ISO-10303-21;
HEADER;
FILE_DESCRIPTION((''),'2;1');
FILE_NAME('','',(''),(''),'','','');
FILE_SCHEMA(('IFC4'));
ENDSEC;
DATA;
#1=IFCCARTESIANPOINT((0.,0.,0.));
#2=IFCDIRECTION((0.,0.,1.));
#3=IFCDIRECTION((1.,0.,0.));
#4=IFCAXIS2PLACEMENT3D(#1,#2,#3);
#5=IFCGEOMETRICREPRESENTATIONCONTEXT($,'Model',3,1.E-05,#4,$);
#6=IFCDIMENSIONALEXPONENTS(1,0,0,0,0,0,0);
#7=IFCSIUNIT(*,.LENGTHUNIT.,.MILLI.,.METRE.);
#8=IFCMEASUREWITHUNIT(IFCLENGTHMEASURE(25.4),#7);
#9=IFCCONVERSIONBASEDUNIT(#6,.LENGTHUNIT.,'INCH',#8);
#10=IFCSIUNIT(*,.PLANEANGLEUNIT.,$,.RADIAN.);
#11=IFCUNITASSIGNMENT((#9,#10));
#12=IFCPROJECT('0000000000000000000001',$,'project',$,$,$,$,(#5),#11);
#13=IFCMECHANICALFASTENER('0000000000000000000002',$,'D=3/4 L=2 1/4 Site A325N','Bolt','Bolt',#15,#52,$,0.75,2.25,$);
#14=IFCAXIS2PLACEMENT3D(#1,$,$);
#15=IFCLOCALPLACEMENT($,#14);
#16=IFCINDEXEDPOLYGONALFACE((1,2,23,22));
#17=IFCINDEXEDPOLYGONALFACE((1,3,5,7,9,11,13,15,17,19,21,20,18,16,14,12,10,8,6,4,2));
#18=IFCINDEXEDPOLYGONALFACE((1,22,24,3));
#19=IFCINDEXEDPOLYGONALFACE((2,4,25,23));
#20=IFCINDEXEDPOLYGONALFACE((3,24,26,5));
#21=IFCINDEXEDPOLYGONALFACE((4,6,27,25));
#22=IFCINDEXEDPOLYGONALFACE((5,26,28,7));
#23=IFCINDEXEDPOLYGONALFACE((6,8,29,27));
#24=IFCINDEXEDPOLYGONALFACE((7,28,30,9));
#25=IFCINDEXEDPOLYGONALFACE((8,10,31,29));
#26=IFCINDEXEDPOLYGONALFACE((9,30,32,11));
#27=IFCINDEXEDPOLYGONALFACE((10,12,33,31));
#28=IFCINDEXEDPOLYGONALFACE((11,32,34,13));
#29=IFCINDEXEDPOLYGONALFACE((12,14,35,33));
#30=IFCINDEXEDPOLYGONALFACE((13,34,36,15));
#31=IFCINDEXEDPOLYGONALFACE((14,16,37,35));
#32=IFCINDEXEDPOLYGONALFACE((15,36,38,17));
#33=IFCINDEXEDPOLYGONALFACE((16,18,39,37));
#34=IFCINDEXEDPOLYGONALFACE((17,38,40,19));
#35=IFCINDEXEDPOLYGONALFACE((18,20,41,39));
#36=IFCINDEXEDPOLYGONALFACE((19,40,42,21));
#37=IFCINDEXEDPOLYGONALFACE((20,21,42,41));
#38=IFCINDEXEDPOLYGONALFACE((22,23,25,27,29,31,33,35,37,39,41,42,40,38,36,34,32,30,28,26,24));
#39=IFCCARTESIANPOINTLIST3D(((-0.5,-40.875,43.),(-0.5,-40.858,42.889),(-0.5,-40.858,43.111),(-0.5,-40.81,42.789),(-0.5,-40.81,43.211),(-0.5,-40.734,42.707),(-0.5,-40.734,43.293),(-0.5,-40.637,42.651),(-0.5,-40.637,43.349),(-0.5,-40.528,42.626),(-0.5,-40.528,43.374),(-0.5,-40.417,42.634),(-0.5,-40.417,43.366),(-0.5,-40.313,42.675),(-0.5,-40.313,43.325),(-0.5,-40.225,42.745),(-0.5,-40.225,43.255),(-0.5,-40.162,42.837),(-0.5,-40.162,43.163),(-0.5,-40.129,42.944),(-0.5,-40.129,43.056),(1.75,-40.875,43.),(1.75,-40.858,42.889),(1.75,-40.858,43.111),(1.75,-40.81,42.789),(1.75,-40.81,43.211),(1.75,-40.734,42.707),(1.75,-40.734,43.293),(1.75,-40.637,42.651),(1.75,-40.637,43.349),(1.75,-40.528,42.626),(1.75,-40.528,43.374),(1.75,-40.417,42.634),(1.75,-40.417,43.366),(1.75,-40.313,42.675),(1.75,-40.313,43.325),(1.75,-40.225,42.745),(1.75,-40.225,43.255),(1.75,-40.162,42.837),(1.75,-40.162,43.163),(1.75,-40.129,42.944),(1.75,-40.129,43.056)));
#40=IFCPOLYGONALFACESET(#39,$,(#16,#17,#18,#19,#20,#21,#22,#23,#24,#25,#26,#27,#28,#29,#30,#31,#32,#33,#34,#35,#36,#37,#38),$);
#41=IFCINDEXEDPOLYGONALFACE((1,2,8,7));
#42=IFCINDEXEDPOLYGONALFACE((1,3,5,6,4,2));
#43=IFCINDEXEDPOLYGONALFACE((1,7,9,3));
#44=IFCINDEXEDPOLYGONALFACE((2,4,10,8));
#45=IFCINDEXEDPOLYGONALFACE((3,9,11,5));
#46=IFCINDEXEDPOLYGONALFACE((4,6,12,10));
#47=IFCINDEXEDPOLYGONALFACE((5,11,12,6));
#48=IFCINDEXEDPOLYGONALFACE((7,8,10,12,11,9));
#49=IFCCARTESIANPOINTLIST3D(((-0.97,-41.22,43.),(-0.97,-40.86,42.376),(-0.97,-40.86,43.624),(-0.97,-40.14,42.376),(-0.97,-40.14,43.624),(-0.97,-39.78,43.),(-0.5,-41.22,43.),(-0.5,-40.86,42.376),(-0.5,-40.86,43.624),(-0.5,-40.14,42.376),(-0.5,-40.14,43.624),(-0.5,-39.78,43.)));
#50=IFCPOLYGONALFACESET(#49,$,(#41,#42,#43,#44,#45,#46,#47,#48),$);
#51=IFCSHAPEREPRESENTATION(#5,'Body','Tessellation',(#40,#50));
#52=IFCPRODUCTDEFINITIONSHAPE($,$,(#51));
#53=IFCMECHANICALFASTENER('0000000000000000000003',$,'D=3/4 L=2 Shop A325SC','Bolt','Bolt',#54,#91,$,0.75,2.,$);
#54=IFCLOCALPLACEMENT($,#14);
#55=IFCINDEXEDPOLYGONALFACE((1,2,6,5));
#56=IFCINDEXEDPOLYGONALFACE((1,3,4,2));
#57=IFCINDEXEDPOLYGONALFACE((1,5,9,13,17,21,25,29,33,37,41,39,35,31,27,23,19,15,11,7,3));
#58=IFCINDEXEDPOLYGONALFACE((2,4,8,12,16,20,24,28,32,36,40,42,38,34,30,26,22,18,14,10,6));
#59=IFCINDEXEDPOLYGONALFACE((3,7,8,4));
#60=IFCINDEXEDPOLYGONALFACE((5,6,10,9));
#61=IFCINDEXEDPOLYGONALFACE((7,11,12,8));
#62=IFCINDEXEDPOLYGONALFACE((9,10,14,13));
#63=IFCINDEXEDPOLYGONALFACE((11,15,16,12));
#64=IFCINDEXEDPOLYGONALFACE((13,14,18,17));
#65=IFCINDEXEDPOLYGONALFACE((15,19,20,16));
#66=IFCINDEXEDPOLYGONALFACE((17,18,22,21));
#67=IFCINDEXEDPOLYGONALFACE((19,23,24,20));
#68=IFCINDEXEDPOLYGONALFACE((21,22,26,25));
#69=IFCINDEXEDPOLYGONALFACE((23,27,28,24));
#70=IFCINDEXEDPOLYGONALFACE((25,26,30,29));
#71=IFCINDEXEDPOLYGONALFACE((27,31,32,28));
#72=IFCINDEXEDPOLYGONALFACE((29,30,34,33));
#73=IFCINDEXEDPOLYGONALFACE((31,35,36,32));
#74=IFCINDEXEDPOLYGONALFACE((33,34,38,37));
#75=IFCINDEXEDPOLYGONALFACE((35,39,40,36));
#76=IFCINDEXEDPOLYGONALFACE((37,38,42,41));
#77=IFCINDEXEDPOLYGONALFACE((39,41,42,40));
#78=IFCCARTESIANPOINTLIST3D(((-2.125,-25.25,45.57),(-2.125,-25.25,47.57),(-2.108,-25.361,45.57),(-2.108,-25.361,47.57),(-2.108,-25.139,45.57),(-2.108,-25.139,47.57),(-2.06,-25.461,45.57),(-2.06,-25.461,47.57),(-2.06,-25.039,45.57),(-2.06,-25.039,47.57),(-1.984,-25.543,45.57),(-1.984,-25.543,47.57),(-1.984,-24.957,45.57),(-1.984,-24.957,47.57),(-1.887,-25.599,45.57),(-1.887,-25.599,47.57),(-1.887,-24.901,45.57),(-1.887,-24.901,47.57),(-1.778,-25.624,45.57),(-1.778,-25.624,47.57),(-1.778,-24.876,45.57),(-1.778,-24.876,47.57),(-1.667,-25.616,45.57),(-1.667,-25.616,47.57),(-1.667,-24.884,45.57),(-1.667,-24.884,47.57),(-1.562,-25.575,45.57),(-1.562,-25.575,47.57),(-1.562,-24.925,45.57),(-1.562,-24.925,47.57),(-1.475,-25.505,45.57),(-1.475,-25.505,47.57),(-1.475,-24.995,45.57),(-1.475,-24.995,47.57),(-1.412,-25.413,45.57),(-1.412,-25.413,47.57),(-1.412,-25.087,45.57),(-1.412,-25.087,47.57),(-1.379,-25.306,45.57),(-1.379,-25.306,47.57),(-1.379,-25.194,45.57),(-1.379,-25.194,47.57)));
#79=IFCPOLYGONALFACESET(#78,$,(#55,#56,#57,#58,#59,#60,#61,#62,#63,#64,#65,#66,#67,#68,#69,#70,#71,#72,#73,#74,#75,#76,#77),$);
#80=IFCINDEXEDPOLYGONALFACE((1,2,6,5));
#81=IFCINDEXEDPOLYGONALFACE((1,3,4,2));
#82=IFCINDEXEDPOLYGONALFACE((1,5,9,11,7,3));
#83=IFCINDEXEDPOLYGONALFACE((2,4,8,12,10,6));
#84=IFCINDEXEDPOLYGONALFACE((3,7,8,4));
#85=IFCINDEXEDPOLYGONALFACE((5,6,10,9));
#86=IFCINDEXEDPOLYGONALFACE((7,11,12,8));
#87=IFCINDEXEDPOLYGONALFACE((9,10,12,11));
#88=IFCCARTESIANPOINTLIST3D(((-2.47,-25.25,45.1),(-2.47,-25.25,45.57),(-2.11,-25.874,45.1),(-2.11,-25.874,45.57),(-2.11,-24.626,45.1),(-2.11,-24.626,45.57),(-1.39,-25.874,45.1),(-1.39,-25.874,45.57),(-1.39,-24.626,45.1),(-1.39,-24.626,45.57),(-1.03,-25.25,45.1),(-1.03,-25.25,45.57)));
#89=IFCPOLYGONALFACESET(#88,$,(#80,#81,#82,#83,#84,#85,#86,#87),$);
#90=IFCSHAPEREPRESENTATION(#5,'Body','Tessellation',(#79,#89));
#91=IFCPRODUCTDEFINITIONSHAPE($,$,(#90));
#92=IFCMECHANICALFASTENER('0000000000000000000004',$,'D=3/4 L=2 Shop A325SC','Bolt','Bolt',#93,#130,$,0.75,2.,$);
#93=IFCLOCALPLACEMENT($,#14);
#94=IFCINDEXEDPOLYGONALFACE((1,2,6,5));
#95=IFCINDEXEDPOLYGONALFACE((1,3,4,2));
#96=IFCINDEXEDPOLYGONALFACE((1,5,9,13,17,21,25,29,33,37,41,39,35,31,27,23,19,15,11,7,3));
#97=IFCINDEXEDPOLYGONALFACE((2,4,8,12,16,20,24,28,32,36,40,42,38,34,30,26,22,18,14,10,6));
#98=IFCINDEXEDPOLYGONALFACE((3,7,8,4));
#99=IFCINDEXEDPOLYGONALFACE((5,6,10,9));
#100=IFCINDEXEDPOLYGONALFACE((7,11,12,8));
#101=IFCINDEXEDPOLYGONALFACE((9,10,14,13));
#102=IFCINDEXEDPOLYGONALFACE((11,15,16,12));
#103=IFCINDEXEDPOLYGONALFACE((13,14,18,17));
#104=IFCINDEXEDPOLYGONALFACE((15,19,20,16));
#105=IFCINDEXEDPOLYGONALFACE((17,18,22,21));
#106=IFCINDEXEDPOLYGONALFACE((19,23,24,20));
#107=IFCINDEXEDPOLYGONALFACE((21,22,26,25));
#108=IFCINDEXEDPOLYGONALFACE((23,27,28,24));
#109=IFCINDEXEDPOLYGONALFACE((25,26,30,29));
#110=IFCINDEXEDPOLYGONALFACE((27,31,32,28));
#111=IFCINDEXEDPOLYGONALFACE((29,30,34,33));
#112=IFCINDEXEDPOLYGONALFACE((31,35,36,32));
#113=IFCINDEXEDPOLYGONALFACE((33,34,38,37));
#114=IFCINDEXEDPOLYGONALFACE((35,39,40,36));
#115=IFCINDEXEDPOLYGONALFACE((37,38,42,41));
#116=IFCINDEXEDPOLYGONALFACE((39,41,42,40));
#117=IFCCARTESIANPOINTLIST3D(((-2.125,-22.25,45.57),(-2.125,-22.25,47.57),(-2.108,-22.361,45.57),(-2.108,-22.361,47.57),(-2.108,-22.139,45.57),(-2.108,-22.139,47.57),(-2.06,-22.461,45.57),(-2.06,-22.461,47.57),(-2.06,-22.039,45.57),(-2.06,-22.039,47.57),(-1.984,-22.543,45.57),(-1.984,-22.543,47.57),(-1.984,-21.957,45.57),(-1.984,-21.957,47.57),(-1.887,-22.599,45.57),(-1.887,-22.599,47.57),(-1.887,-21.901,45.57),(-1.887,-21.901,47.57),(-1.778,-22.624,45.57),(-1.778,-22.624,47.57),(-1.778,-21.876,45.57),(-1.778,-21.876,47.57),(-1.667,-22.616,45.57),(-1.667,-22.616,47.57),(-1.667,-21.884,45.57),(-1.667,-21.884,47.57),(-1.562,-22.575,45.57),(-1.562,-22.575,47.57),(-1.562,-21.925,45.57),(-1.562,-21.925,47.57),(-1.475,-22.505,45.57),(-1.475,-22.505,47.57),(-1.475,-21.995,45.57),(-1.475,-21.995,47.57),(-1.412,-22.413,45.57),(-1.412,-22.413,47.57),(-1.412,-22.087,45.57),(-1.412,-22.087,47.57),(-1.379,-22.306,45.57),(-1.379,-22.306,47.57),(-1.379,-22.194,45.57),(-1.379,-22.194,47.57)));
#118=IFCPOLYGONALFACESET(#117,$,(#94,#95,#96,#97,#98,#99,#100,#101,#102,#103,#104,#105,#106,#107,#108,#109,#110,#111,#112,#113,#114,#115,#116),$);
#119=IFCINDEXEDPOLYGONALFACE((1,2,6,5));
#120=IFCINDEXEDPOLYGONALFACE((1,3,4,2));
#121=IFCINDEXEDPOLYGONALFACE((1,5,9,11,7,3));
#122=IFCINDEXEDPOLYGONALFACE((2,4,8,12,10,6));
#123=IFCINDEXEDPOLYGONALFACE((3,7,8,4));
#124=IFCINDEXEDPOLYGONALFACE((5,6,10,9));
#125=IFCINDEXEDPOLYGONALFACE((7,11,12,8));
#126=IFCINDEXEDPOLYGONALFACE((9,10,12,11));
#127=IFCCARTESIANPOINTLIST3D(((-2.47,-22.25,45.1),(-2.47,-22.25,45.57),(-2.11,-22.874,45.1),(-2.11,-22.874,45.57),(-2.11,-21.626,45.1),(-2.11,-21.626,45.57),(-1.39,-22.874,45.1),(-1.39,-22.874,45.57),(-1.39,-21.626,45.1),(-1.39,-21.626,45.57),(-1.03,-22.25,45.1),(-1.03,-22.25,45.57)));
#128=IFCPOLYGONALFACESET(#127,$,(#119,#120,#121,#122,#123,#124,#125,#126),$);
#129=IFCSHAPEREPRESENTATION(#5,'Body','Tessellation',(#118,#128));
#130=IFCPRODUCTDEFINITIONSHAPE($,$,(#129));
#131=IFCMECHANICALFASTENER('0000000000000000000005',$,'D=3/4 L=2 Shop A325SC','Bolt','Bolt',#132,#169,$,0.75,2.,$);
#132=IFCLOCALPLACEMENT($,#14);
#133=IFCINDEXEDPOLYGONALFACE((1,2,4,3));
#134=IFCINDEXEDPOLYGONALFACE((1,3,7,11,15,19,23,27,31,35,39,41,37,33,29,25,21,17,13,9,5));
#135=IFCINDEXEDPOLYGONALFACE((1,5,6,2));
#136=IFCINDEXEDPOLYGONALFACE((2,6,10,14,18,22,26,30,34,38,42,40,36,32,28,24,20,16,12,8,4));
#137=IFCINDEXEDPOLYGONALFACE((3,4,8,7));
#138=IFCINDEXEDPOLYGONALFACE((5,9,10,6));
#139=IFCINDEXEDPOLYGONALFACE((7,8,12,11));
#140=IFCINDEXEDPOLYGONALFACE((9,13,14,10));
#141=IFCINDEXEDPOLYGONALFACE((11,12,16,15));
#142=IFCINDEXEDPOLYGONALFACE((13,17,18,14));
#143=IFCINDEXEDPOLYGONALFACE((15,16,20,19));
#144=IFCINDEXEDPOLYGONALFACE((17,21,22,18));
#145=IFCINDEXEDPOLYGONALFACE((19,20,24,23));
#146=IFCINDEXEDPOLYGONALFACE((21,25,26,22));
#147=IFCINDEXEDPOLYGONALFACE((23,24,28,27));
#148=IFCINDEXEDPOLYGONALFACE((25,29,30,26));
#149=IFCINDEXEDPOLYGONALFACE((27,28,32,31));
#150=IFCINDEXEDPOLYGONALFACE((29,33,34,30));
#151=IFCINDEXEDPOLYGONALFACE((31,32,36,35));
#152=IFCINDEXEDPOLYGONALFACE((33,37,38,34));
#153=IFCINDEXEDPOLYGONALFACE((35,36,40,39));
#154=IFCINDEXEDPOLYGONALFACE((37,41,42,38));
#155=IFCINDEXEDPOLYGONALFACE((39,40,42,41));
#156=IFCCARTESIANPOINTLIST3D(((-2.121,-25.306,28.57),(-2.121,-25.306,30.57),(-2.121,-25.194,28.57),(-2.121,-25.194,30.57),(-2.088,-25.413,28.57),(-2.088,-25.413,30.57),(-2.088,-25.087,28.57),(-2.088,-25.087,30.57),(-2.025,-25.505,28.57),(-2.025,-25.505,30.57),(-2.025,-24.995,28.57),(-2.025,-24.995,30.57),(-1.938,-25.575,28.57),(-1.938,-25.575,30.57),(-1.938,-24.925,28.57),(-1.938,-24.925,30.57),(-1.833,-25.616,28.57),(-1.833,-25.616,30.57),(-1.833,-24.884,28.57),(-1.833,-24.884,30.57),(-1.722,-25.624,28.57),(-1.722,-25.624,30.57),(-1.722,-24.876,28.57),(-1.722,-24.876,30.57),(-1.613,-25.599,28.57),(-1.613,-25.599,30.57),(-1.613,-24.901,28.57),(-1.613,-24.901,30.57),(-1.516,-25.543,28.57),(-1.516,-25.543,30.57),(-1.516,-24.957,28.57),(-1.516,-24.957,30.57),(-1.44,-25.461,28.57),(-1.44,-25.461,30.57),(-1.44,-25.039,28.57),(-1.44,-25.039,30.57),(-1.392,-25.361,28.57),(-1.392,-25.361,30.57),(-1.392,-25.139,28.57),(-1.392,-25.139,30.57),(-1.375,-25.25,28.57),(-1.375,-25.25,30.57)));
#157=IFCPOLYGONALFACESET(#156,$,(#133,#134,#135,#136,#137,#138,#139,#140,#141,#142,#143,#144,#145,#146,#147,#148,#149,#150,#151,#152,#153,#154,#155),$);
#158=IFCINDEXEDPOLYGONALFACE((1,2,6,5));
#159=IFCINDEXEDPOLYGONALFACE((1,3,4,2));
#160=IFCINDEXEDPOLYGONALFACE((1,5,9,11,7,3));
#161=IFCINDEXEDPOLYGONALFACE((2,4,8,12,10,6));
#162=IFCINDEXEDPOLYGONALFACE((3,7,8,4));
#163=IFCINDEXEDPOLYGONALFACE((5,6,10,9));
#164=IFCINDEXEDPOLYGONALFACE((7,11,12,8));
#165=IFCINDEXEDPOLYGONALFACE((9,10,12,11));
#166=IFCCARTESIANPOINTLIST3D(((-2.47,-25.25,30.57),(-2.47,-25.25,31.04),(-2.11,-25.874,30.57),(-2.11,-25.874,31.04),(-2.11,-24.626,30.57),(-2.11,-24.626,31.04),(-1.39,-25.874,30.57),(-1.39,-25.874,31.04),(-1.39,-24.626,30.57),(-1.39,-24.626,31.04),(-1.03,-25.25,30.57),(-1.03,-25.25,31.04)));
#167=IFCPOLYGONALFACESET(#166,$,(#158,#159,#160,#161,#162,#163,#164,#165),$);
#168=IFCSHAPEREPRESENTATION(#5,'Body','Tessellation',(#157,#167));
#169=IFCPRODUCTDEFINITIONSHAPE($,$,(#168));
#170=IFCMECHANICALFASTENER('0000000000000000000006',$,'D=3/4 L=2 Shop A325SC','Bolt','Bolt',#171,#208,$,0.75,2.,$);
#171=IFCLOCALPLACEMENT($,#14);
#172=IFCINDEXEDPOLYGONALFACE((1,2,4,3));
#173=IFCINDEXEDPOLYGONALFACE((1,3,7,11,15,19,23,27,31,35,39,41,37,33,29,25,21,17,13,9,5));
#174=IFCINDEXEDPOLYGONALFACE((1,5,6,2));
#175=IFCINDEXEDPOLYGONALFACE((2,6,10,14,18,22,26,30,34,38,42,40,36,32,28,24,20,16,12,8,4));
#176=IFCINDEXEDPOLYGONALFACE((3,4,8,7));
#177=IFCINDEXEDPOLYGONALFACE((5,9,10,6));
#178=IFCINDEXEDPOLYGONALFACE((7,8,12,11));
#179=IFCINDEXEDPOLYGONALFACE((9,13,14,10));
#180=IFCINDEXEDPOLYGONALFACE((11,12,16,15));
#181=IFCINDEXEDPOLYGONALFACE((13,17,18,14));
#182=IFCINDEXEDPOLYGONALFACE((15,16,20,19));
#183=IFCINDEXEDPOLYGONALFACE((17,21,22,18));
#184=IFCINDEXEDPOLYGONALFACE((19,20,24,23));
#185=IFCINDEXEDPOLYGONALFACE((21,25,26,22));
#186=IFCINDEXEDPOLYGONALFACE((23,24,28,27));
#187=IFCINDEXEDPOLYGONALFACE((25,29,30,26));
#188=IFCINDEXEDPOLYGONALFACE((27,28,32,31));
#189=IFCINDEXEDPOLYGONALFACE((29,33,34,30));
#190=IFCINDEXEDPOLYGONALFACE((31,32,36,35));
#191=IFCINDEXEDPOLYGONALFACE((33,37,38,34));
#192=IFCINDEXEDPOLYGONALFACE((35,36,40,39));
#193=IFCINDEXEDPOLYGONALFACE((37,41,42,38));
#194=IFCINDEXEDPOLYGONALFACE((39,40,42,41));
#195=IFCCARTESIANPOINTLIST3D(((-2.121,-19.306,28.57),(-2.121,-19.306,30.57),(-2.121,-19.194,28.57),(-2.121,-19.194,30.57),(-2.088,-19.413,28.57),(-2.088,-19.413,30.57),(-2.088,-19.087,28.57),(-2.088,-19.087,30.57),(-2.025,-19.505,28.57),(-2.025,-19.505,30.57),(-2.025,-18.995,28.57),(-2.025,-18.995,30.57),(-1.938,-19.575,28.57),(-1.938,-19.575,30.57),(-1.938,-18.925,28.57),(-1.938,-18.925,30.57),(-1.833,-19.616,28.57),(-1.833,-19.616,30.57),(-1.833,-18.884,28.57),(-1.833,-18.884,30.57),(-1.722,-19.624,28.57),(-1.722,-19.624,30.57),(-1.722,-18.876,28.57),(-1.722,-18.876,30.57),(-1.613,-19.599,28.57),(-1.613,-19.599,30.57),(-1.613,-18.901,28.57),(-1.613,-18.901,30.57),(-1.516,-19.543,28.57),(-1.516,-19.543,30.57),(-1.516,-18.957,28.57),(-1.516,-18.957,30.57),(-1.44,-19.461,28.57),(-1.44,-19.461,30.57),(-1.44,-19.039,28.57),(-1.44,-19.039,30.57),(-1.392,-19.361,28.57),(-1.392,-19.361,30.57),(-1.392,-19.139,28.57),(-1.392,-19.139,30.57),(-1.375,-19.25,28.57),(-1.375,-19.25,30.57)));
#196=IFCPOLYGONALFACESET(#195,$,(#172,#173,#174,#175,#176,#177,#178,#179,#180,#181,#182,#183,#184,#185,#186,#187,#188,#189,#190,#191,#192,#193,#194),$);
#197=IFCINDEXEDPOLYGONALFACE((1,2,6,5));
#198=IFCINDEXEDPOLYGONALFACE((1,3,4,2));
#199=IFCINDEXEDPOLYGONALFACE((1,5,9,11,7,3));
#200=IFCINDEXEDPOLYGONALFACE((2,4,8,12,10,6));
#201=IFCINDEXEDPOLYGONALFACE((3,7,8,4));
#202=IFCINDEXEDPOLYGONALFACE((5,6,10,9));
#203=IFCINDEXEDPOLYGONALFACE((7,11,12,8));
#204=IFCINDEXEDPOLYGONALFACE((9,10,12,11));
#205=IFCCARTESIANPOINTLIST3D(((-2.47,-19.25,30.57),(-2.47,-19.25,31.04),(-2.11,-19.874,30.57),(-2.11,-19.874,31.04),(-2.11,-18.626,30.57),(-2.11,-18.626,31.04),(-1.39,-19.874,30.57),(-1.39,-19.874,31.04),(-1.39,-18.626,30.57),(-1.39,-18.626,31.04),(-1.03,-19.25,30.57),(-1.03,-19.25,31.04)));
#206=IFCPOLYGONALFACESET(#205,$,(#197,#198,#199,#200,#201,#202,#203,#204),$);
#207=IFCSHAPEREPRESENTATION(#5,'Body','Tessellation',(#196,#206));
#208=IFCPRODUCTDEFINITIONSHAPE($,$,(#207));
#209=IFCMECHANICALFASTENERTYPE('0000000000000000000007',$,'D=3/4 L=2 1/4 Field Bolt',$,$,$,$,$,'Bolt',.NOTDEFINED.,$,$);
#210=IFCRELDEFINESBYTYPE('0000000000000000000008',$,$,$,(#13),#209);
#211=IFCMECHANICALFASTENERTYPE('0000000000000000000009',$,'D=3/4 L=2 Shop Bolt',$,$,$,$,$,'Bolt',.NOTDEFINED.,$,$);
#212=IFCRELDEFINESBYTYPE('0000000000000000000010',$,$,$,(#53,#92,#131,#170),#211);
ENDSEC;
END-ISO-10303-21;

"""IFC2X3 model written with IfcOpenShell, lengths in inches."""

from ifc_helpers import new_model, entity, si_unit, converted_unit, frame, origin_with_axes, origin_2d_with_axis, place, context, project, polyline, circle, outline, extrude, source, transform, mapped, type_object, type_shapes, element, save


model = new_model("IFC2X3")

# Units and contexts
model_context = context("Model", 3, precision=1e-05, world=origin_with_axes())
ifc_project = project(units=[converted_unit("LENGTHUNIT", "INCH", entity("IfcLengthMeasure", 25.4), si_unit("LENGTHUNIT", "METRE", prefix="MILLI"), dimensions=[1, 0, 0, 0, 0, 0, 0]), si_unit("PLANEANGLEUNIT", "RADIAN")], contexts=[model_context])

# Mechanical fasteners
placement_1 = place(None, origin_with_axes())
placement_2 = place(placement_1, origin_with_axes())
mechanical_fastener_type_1 = type_object("IfcMechanicalFastenerType", Name="D=3/4 L=2 1/4 Field Bolt", ElementType="Bolt")
shared_shape_1 = source(origin_with_axes(), model_context, "Body", "SweptSolid", [
    extrude(circle(Radius=0.375, at=origin_2d_with_axis()), frame((0.0, 0.0, 0.0), z_axis=(1.0, 0.0, 0.0), x_axis=(0.0, 1.0, 0.0)), (0.0, 0.0, 1.0), 2.25),
    extrude(outline(polyline([(-0.72, 0.0), (-0.36, 0.624), (0.36, 0.624), (0.72, 0.0), (0.36, -0.624), (-0.36, -0.624), (-0.72, 0.0)])), frame((0.0, 0.0, 0.0), z_axis=(1.0, 0.0, 0.0), x_axis=(0.0, 1.0, 0.0)), (0.0, 0.0, -1.0), 0.47),
])
type_shapes(mechanical_fastener_type_1, [shared_shape_1])
placement_3 = place(placement_2, frame((0.0, -43.0, 46.0), z_axis=(0.0, 0.0, 1.0), x_axis=(1.0, 0.0, 0.0)))
placement_4 = place(placement_3, frame((-0.5, 2.5, -3.0), z_axis=(0.0, 0.0, -1.0), x_axis=(1.0, 0.0, 0.0)))
for number, where, z_axis, x_axis, name in (
    (1, (0.0, 0.0, 0.0), (0.0, 0.0, 1.0), (1.0, 0.0, 0.0), "D=3/4 L=2 1/4 Site A325N"),
):
    element("IfcMechanicalFastener", number, at=place(placement_4, frame(where, z_axis=z_axis, x_axis=x_axis)), type_object=mechanical_fastener_type_1, Name=name, Description="Bolt", ObjectType="Bolt", NominalDiameter=0.75, NominalLength=2.25, context=model_context, shape_type="MappedRepresentation", body=[
        mapped(shared_shape_1, transform((0.0, 0.0, 0.0), scale=1.0)),
    ])
mechanical_fastener_type_2 = type_object("IfcMechanicalFastenerType", Name="D=3/4 L=2 Shop Bolt", ElementType="Bolt")
shared_shape_2 = source(origin_with_axes(), model_context, "Body", "SweptSolid", [
    extrude(circle(Radius=0.375, at=origin_2d_with_axis()), frame((0.0, 0.0, 0.0), z_axis=(1.0, 0.0, 0.0), x_axis=(0.0, 1.0, 0.0)), (0.0, 0.0, 1.0), 2.0),
    extrude(outline(polyline([(-0.72, 0.0), (-0.36, 0.624), (0.36, 0.624), (0.72, 0.0), (0.36, -0.624), (-0.36, -0.624), (-0.72, 0.0)])), frame((0.0, 0.0, 0.0), z_axis=(1.0, 0.0, 0.0), x_axis=(0.0, 1.0, 0.0)), (0.0, 0.0, -1.0), 0.47),
])
type_shapes(mechanical_fastener_type_2, [shared_shape_2])
placement_5 = place(placement_2, frame((0.0, 0.0, 46.0), z_axis=(0.0, 0.0, 1.0), x_axis=(0.0, -1.0, 0.0)))
placement_6 = place(placement_5, frame((25.25, -1.75, -0.43), z_axis=(1.0, 0.0, 0.0), x_axis=(0.0, 0.0, 1.0)))
for number, where, z_axis, x_axis, name in (
    (2, (0.0, 0.0, 0.0), (0.0, 0.0, 1.0), (1.0, 0.0, 0.0), "D=3/4 L=2 Shop A325SC"),
    (3, (0.0, 0.0, -3.0), (0.0, 0.0, 1.0), (1.0, 0.0, 0.0), "D=3/4 L=2 Shop A325SC"),
):
    element("IfcMechanicalFastener", number, at=place(placement_6, frame(where, z_axis=z_axis, x_axis=x_axis)), type_object=mechanical_fastener_type_2, Name=name, Description="Bolt", ObjectType="Bolt", NominalDiameter=0.75, NominalLength=2.0, context=model_context, shape_type="MappedRepresentation", body=[
        mapped(shared_shape_2, transform((0.0, 0.0, 0.0), scale=1.0)),
    ])
placement_7 = place(placement_5, frame((25.25, -1.75, -15.43), z_axis=(1.0, 0.0, 0.0), x_axis=(0.0, 0.0, -1.0)))
for number, where, z_axis, x_axis, name in (
    (4, (0.0, 0.0, 0.0), (0.0, 0.0, 1.0), (1.0, 0.0, 0.0), "D=3/4 L=2 Shop A325SC"),
    (5, (0.0, 0.0, -6.0), (0.0, 0.0, 1.0), (1.0, 0.0, 0.0), "D=3/4 L=2 Shop A325SC"),
):
    element("IfcMechanicalFastener", number, at=place(placement_7, frame(where, z_axis=z_axis, x_axis=x_axis)), type_object=mechanical_fastener_type_2, Name=name, Description="Bolt", ObjectType="Bolt", NominalDiameter=0.75, NominalLength=2.0, context=model_context, shape_type="MappedRepresentation", body=[
        mapped(shared_shape_2, transform((0.0, 0.0, 0.0), scale=1.0)),
    ])

save(model, "model.ifc")
